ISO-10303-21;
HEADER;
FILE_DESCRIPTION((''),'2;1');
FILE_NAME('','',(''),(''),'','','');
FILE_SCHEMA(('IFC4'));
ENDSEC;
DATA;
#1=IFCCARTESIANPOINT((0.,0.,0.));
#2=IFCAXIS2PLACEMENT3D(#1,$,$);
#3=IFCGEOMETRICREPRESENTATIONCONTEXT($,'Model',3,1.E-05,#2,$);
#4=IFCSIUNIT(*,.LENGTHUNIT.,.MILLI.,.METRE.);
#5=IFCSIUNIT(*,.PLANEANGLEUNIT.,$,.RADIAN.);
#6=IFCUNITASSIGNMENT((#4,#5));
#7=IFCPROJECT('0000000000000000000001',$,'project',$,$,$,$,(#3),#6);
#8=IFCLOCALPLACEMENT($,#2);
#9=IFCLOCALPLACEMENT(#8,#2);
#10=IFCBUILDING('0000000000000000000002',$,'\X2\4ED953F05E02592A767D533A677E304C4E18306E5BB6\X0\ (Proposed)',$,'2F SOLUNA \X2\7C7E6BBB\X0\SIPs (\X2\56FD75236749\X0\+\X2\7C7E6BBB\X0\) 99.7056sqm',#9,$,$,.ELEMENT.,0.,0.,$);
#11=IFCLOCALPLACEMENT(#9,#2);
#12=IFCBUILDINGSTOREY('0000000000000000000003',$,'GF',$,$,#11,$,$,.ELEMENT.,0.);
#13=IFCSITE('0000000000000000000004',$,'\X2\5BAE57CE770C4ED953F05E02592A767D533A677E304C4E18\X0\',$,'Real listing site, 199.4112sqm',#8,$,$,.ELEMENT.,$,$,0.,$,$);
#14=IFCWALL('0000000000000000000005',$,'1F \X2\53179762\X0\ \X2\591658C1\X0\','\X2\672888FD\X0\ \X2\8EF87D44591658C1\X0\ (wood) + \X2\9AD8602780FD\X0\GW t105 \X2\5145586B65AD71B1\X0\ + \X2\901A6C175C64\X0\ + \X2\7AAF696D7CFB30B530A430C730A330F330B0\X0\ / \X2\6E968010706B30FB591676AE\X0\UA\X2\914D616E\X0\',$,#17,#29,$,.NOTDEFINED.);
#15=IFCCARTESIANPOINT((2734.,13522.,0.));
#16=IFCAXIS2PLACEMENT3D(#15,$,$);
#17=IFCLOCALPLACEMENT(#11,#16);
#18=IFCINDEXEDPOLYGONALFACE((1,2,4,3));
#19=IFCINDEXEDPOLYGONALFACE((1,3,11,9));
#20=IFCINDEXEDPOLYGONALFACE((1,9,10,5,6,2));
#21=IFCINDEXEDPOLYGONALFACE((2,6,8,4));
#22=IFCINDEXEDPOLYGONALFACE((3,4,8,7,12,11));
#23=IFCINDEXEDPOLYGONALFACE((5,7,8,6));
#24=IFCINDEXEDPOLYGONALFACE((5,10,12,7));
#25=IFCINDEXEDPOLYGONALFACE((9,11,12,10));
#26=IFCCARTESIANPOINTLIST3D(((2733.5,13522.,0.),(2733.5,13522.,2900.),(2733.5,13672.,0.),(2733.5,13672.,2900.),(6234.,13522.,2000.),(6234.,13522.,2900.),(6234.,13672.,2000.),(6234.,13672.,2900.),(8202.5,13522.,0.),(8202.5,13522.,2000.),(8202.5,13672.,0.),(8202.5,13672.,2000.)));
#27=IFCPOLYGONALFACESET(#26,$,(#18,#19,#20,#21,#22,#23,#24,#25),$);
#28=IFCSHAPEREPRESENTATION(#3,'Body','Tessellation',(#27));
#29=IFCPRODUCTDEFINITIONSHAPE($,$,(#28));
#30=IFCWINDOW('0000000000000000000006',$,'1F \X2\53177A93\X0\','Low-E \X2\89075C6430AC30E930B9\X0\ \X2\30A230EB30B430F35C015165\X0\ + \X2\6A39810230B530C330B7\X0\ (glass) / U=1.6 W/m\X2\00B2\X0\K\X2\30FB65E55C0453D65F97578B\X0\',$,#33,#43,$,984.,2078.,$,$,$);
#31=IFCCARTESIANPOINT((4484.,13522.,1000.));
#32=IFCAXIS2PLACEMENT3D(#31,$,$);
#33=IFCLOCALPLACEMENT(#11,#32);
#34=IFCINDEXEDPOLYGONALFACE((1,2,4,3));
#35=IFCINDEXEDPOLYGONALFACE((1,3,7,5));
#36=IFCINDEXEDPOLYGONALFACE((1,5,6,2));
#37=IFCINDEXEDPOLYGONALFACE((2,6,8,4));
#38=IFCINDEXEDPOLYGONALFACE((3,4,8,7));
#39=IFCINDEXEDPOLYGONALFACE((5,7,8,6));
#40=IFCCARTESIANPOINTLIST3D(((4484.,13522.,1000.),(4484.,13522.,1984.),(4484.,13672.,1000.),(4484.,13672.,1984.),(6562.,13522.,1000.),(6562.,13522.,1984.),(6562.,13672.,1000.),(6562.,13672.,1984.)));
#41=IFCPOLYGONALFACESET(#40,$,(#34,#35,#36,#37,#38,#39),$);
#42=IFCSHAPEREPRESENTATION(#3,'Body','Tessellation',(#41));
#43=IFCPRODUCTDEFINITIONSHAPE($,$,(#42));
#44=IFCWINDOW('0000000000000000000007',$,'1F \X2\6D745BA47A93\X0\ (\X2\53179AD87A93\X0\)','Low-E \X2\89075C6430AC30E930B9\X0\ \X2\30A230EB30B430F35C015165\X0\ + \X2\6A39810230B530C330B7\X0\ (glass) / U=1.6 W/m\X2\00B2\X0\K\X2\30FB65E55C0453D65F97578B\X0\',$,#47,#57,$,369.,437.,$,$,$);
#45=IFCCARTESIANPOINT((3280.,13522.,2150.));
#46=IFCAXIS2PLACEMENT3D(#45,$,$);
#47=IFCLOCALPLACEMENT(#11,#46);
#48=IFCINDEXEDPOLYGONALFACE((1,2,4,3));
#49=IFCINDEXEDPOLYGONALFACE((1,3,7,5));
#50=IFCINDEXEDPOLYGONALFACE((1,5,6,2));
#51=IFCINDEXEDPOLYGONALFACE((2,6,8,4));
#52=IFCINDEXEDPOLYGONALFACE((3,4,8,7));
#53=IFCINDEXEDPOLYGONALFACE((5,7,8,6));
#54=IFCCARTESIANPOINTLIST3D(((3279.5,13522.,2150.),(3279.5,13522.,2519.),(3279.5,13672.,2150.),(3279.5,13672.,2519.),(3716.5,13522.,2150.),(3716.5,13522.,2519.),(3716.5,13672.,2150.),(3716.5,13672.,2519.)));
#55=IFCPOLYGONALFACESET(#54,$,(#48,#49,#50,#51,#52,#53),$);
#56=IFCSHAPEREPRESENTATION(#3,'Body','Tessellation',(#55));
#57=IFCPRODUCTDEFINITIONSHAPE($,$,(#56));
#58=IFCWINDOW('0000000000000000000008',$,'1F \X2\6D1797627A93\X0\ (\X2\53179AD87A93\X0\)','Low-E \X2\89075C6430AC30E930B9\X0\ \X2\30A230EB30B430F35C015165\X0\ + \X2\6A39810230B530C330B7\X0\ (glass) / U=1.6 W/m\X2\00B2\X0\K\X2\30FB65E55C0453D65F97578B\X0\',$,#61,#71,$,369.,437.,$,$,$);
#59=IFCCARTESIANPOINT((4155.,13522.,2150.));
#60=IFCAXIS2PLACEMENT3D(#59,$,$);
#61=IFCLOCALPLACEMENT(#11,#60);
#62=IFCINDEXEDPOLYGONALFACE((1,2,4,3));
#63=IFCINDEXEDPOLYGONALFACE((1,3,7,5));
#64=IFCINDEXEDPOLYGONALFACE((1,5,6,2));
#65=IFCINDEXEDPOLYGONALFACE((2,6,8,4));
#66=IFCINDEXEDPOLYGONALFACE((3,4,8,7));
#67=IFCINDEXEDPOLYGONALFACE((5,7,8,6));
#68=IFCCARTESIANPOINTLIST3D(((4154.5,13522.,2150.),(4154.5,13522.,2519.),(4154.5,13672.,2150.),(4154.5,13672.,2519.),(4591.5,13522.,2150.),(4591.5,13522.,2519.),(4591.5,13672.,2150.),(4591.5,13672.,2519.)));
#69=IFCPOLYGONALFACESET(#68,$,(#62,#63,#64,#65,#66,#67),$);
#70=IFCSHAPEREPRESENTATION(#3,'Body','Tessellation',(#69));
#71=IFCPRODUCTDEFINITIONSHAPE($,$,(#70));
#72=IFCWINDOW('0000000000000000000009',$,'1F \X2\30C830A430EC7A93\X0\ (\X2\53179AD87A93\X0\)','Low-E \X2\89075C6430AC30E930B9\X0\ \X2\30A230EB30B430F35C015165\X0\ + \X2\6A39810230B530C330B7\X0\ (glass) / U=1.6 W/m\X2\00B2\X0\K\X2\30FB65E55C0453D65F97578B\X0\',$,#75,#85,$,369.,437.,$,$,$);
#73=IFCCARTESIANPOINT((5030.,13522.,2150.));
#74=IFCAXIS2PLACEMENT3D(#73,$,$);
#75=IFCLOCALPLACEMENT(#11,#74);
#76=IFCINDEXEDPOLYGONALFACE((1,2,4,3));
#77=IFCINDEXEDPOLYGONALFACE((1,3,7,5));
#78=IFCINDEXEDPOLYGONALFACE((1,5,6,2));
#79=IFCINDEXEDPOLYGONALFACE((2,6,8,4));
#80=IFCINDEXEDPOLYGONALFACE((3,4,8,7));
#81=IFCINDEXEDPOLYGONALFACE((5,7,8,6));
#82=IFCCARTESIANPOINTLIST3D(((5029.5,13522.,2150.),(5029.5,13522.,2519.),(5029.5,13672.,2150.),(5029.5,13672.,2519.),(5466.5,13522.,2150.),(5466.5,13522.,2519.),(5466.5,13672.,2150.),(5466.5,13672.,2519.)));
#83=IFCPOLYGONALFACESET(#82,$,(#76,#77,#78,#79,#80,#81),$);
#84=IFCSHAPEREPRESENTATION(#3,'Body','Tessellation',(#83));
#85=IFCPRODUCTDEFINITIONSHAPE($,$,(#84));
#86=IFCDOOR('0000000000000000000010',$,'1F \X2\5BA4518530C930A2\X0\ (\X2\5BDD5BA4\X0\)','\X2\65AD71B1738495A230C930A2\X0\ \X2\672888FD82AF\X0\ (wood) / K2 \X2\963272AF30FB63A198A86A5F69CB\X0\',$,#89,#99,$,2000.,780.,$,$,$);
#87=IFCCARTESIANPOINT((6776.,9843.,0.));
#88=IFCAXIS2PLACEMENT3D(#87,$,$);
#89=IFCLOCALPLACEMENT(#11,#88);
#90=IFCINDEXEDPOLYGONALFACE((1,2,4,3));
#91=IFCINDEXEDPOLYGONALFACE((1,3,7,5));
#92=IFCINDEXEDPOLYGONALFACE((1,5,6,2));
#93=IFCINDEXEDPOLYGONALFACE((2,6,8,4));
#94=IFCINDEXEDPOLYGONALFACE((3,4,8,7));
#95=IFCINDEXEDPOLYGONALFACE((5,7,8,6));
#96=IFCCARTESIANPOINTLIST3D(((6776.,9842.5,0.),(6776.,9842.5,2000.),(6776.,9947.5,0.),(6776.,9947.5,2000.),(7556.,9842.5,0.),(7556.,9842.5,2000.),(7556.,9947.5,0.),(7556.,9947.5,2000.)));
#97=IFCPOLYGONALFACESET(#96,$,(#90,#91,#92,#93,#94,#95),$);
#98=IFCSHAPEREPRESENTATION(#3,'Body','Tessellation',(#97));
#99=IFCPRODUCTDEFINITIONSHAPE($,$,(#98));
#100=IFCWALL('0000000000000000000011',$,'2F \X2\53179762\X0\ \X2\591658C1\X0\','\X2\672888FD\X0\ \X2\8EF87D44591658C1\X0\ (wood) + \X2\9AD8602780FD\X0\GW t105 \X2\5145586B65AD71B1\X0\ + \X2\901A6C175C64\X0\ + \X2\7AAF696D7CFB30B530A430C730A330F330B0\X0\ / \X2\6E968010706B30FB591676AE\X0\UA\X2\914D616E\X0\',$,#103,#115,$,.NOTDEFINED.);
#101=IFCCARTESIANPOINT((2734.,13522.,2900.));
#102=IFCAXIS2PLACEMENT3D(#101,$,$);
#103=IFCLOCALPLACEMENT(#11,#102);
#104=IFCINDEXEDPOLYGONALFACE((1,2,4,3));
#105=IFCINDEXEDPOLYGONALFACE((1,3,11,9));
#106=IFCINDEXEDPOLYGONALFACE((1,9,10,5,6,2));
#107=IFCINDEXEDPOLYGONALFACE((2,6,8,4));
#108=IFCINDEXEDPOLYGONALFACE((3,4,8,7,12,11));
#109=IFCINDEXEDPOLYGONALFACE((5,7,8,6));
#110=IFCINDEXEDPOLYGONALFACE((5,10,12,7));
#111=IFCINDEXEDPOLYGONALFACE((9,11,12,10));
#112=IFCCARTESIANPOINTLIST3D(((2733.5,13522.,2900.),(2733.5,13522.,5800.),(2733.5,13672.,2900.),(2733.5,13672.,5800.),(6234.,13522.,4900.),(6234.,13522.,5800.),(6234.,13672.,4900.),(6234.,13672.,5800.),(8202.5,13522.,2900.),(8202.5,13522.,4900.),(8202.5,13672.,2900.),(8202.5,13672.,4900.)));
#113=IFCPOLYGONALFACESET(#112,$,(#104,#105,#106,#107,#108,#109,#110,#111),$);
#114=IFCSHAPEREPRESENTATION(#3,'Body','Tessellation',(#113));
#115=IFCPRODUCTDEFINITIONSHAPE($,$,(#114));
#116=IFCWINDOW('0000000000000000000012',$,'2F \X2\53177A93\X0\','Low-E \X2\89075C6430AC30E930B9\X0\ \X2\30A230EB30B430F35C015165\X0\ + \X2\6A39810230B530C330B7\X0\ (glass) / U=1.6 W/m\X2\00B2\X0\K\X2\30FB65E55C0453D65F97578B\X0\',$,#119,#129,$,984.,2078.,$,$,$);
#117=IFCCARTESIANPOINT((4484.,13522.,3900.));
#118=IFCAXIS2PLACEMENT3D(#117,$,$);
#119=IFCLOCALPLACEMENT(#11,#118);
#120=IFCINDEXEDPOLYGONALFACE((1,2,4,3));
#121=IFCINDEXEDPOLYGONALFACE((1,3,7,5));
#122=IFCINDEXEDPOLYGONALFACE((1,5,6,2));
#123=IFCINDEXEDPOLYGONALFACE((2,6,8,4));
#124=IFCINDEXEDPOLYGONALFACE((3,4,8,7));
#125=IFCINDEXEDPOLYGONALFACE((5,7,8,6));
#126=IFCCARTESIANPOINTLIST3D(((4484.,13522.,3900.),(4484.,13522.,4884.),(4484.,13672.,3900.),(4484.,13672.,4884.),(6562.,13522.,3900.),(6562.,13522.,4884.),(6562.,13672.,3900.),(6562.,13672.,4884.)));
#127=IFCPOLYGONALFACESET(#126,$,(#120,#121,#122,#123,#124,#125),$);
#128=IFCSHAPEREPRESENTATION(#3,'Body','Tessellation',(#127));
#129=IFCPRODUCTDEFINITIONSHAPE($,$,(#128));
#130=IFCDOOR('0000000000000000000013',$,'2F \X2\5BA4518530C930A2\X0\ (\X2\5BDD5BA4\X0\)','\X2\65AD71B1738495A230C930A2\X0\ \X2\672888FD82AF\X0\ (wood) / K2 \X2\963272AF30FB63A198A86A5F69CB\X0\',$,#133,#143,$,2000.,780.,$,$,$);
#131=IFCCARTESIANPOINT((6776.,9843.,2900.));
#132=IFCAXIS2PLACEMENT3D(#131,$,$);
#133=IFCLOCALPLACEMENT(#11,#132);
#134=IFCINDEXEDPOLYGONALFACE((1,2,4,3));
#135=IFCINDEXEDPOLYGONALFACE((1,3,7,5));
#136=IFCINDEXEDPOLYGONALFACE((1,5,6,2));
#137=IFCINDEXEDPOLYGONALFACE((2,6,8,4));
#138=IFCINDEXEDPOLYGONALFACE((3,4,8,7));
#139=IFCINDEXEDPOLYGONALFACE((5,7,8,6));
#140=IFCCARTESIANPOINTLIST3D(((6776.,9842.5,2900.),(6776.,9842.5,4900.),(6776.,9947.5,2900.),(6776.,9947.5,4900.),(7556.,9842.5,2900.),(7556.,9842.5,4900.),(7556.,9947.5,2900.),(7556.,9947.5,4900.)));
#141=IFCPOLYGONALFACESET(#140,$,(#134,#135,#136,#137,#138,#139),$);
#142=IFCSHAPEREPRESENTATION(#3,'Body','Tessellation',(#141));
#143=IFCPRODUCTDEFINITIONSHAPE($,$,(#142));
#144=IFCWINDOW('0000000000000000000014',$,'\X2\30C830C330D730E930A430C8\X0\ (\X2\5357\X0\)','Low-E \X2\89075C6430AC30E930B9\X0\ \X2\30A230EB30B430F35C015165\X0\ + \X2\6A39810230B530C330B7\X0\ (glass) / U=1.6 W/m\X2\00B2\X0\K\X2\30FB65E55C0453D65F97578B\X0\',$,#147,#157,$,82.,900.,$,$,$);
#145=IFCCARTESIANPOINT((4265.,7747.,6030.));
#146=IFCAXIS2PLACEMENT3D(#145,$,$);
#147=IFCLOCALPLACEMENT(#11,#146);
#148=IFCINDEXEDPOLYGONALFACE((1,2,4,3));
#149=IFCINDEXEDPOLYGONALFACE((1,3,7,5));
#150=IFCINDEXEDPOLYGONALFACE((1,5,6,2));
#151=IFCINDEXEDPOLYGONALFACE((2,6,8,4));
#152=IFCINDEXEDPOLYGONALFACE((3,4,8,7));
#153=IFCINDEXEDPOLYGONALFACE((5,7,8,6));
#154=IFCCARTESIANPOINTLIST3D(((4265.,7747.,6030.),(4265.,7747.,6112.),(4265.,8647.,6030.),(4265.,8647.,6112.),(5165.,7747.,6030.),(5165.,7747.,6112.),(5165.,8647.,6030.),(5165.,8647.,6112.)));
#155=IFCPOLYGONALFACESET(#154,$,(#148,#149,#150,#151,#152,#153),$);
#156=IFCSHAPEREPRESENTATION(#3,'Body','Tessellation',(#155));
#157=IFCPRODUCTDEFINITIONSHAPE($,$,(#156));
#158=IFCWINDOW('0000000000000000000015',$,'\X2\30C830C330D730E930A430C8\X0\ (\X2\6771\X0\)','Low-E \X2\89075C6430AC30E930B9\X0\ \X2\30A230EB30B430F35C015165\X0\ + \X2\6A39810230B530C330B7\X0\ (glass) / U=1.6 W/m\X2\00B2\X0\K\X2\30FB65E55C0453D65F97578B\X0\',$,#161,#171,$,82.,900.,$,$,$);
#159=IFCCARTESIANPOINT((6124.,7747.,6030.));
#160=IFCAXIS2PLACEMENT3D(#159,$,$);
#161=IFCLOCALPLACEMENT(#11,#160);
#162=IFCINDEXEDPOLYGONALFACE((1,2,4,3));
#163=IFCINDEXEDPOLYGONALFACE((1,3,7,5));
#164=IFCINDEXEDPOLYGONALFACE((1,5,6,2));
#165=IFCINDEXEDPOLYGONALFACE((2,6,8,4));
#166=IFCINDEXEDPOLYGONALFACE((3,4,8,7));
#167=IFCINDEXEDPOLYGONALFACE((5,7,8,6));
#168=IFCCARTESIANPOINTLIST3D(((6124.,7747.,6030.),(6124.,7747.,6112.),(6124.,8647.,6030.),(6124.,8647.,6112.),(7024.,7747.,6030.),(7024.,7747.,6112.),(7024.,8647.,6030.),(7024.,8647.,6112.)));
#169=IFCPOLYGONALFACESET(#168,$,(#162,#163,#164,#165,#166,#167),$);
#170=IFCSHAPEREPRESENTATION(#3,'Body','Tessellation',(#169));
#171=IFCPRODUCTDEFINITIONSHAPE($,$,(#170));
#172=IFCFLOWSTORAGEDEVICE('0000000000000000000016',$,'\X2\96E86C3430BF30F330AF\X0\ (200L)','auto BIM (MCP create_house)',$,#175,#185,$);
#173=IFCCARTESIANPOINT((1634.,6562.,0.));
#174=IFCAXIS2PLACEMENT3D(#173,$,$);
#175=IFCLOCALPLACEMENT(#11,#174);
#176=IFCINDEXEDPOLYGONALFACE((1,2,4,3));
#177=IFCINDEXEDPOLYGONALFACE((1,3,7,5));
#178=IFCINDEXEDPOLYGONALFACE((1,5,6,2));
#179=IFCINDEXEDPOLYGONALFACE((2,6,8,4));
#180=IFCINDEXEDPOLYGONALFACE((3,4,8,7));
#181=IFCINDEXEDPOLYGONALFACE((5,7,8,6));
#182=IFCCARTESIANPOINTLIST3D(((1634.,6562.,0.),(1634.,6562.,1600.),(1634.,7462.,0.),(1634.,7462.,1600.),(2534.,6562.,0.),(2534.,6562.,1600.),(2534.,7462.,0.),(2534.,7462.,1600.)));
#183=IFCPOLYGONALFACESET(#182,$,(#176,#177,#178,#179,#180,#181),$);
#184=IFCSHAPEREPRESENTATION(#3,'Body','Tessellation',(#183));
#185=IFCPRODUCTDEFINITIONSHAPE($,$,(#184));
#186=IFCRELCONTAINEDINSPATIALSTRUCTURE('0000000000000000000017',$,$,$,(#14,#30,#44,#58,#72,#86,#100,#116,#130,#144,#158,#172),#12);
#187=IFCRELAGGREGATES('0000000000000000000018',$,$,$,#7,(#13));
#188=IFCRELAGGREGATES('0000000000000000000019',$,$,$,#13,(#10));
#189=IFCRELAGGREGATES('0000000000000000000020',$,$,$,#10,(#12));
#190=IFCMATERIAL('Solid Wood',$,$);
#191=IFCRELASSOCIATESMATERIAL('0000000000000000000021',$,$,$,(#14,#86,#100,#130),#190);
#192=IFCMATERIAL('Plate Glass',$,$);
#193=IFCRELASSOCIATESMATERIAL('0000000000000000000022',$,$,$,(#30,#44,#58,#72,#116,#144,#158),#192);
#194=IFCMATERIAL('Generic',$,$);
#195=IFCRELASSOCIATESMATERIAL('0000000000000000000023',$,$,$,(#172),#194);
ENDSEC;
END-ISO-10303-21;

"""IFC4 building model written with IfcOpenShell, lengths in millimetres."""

from ifc_helpers import new_model, si_unit, frame, frame_2d, origin, place, context, project, spatial, rectangle, extrude, material, element, fill, save


model = new_model("IFC4")

# Units and contexts
model_context = context("Model", 3, precision=1e-05, world=origin())
ifc_project = project(units=[si_unit("LENGTHUNIT", "METRE", prefix="MILLI"), si_unit("PLANEANGLEUNIT", "RADIAN")], contexts=[model_context])

# Site, building, storey
site_placement = place(None, origin())
site = spatial("IfcSite", under=ifc_project, at=site_placement, Name="宮城県仙台市太白区松が丘", ObjectType="Real listing site, 199.4112sqm", CompositionType="ELEMENT", RefElevation=0.0)
building_placement = place(site_placement, origin())
building = spatial("IfcBuilding", under=site, at=building_placement, Name="仙台市太白区松が丘の家 (Proposed)", ObjectType="2F SOLUNA 籾殻SIPs (国産杉+籾殻) 99.7056sqm", CompositionType="ELEMENT", ElevationOfRefHeight=0.0, ElevationOfTerrain=0.0)
storey_placement = place(building_placement, origin())
storey = spatial("IfcBuildingStorey", under=building, at=storey_placement, Name="GF", CompositionType="ELEMENT", Elevation=0.0)

# Wall, openings, windows
ifc_material_1 = material(Name="Solid Wood")
wall_1_placement = place(storey_placement, frame((2734.0, 13522.0, 0.0)))
wall_1 = element("IfcWall", 1, at=wall_1_placement, inside=storey, material=ifc_material_1, Name="1F 北面 外壁", Description="木製 軸組外壁 (wood) + 高性能GW t105 充填断熱 + 通気層 + 窯業系サイディング / 準耐火・外皮UA配慮", PredefinedType="NOTDEFINED", context=model_context, shape_type="SweptSolid", body=[
    extrude(rectangle(XDim=5469.0, YDim=150.0, at=frame_2d((2734.0, 75.0))), frame((2734.0, 13522.0, 0.0)), (0.0, 0.0, 1.0), 2900.0),
])
opening_1_placement = place(storey_placement, frame((4484.0, 13522.0, 1000.0)))
opening_1 = element("IfcOpeningElement", 2, at=opening_1_placement, cuts=wall_1, PredefinedType="NOTDEFINED", context=model_context, shape_type="SweptSolid", body=[
    extrude(rectangle(XDim=2078.0, YDim=150.0, at=frame_2d((1039.0, 75.0))), frame((4484.0, 13522.0, 1000.0)), (0.0, 0.0, 1.0), 984.0),
])
opening_2_placement = place(storey_placement, frame((3280.0, 13522.0, 2150.0)))
opening_2 = element("IfcOpeningElement", 3, at=opening_2_placement, cuts=wall_1, PredefinedType="NOTDEFINED", context=model_context, shape_type="SweptSolid", body=[
    extrude(rectangle(XDim=437.0, YDim=150.0, at=frame_2d((218.0, 75.0))), frame((3280.0, 13522.0, 2150.0)), (0.0, 0.0, 1.0), 369.0),
])
opening_3_placement = place(storey_placement, frame((4155.0, 13522.0, 2150.0)))
opening_3 = element("IfcOpeningElement", 4, at=opening_3_placement, cuts=wall_1, PredefinedType="NOTDEFINED", context=model_context, shape_type="SweptSolid", body=[
    extrude(rectangle(XDim=437.0, YDim=150.0, at=frame_2d((218.0, 75.0))), frame((4155.0, 13522.0, 2150.0)), (0.0, 0.0, 1.0), 369.0),
])
opening_4_placement = place(storey_placement, frame((5030.0, 13522.0, 2150.0)))
opening_4 = element("IfcOpeningElement", 5, at=opening_4_placement, cuts=wall_1, PredefinedType="NOTDEFINED", context=model_context, shape_type="SweptSolid", body=[
    extrude(rectangle(XDim=437.0, YDim=150.0, at=frame_2d((218.0, 75.0))), frame((5030.0, 13522.0, 2150.0)), (0.0, 0.0, 1.0), 369.0),
])
ifc_material_2 = material(Name="Plate Glass")
window_1_placement = place(storey_placement, frame((4484.0, 13522.0, 1000.0)))
window_1 = element("IfcWindow", 6, at=window_1_placement, inside=storey, material=ifc_material_2, Name="1F 北窓", Description="Low-E 複層ガラス アルゴン封入 + 樹脂サッシ (glass) / U=1.6 W/m²K・日射取得型", OverallHeight=984.0, OverallWidth=2078.0, context=model_context, shape_type="SweptSolid", body=[
    extrude(rectangle(XDim=2078.0, YDim=150.0, at=frame_2d((1039.0, 75.0))), frame((4484.0, 13522.0, 1000.0)), (0.0, 0.0, 1.0), 984.0),
])
fill(opening_1, window_1)
window_2_placement = place(storey_placement, frame((3280.0, 13522.0, 2150.0)))
window_2 = element("IfcWindow", 7, at=window_2_placement, inside=storey, material=ifc_material_2, Name="1F 浴室窓 (北高窓)", Description="Low-E 複層ガラス アルゴン封入 + 樹脂サッシ (glass) / U=1.6 W/m²K・日射取得型", OverallHeight=369.0, OverallWidth=437.0, context=model_context, shape_type="SweptSolid", body=[
    extrude(rectangle(XDim=437.0, YDim=150.0, at=frame_2d((218.0, 75.0))), frame((3280.0, 13522.0, 2150.0)), (0.0, 0.0, 1.0), 369.0),
])
fill(opening_2, window_2)
window_3_placement = place(storey_placement, frame((4155.0, 13522.0, 2150.0)))
window_3 = element("IfcWindow", 8, at=window_3_placement, inside=storey, material=ifc_material_2, Name="1F 洗面窓 (北高窓)", Description="Low-E 複層ガラス アルゴン封入 + 樹脂サッシ (glass) / U=1.6 W/m²K・日射取得型", OverallHeight=369.0, OverallWidth=437.0, context=model_context, shape_type="SweptSolid", body=[
    extrude(rectangle(XDim=437.0, YDim=150.0, at=frame_2d((218.0, 75.0))), frame((4155.0, 13522.0, 2150.0)), (0.0, 0.0, 1.0), 369.0),
])
fill(opening_3, window_3)
window_4_placement = place(storey_placement, frame((5030.0, 13522.0, 2150.0)))
window_4 = element("IfcWindow", 9, at=window_4_placement, inside=storey, material=ifc_material_2, Name="1F トイレ窓 (北高窓)", Description="Low-E 複層ガラス アルゴン封入 + 樹脂サッシ (glass) / U=1.6 W/m²K・日射取得型", OverallHeight=369.0, OverallWidth=437.0, context=model_context, shape_type="SweptSolid", body=[
    extrude(rectangle(XDim=437.0, YDim=150.0, at=frame_2d((218.0, 75.0))), frame((5030.0, 13522.0, 2150.0)), (0.0, 0.0, 1.0), 369.0),
])
fill(opening_4, window_4)

# Door
door_1_placement = place(storey_placement, frame((6776.0, 9843.0, 0.0)))
element("IfcDoor", 10, at=door_1_placement, inside=storey, material=ifc_material_1, Name="1F 室内ドア (寝室)", Description="断熱玄関ドア 木製芯 (wood) / K2 防犯・採風機構", OverallHeight=2000.0, OverallWidth=780.0, context=model_context, shape_type="SweptSolid", body=[
    extrude(rectangle(XDim=780.0, YDim=105.0, at=frame_2d((390.0, 52.0))), frame((6776.0, 9843.0, 0.0)), (0.0, 0.0, 1.0), 2000.0),
])

# Wall, opening, window
wall_2_placement = place(storey_placement, frame((2734.0, 13522.0, 2900.0)))
wall_2 = element("IfcWall", 11, at=wall_2_placement, inside=storey, material=ifc_material_1, Name="2F 北面 外壁", Description="木製 軸組外壁 (wood) + 高性能GW t105 充填断熱 + 通気層 + 窯業系サイディング / 準耐火・外皮UA配慮", PredefinedType="NOTDEFINED", context=model_context, shape_type="SweptSolid", body=[
    extrude(rectangle(XDim=5469.0, YDim=150.0, at=frame_2d((2734.0, 75.0))), frame((2734.0, 13522.0, 2900.0)), (0.0, 0.0, 1.0), 2900.0),
])
opening_5_placement = place(storey_placement, frame((4484.0, 13522.0, 3900.0)))
opening_5 = element("IfcOpeningElement", 12, at=opening_5_placement, cuts=wall_2, PredefinedType="NOTDEFINED", context=model_context, shape_type="SweptSolid", body=[
    extrude(rectangle(XDim=2078.0, YDim=150.0, at=frame_2d((1039.0, 75.0))), frame((4484.0, 13522.0, 3900.0)), (0.0, 0.0, 1.0), 984.0),
])
window_5_placement = place(storey_placement, frame((4484.0, 13522.0, 3900.0)))
window_5 = element("IfcWindow", 13, at=window_5_placement, inside=storey, material=ifc_material_2, Name="2F 北窓", Description="Low-E 複層ガラス アルゴン封入 + 樹脂サッシ (glass) / U=1.6 W/m²K・日射取得型", OverallHeight=984.0, OverallWidth=2078.0, context=model_context, shape_type="SweptSolid", body=[
    extrude(rectangle(XDim=2078.0, YDim=150.0, at=frame_2d((1039.0, 75.0))), frame((4484.0, 13522.0, 3900.0)), (0.0, 0.0, 1.0), 984.0),
])
fill(opening_5, window_5)

# Door
door_2_placement = place(storey_placement, frame((6776.0, 9843.0, 2900.0)))
element("IfcDoor", 14, at=door_2_placement, inside=storey, material=ifc_material_1, Name="2F 室内ドア (寝室)", Description="断熱玄関ドア 木製芯 (wood) / K2 防犯・採風機構", OverallHeight=2000.0, OverallWidth=780.0, context=model_context, shape_type="SweptSolid", body=[
    extrude(rectangle(XDim=780.0, YDim=105.0, at=frame_2d((390.0, 52.0))), frame((6776.0, 9843.0, 2900.0)), (0.0, 0.0, 1.0), 2000.0),
])

# Windows
window_6_placement = place(storey_placement, frame((4265.0, 7747.0, 6030.0)))
element("IfcWindow", 15, at=window_6_placement, inside=storey, material=ifc_material_2, Name="トップライト (南)", Description="Low-E 複層ガラス アルゴン封入 + 樹脂サッシ (glass) / U=1.6 W/m²K・日射取得型", OverallHeight=82.0, OverallWidth=900.0, context=model_context, shape_type="SweptSolid", body=[
    extrude(rectangle(XDim=900.0, YDim=900.0, at=frame_2d((450.0, 450.0))), frame((4265.0, 7747.0, 6030.0)), (0.0, 0.0, 1.0), 82.0),
])
window_7_placement = place(storey_placement, frame((6124.0, 7747.0, 6030.0)))
element("IfcWindow", 16, at=window_7_placement, inside=storey, material=ifc_material_2, Name="トップライト (東)", Description="Low-E 複層ガラス アルゴン封入 + 樹脂サッシ (glass) / U=1.6 W/m²K・日射取得型", OverallHeight=82.0, OverallWidth=900.0, context=model_context, shape_type="SweptSolid", body=[
    extrude(rectangle(XDim=900.0, YDim=900.0, at=frame_2d((450.0, 450.0))), frame((6124.0, 7747.0, 6030.0)), (0.0, 0.0, 1.0), 82.0),
])

# Flow storage device
ifc_material_3 = material(Name="Generic")
flow_storage_device_placement = place(storey_placement, frame((1634.0, 6562.0, 0.0)))
element("IfcFlowStorageDevice", 17, at=flow_storage_device_placement, inside=storey, material=ifc_material_3, Name="雨水タンク (200L)", Description="auto BIM (MCP create_house)", context=model_context, shape_type="SweptSolid", body=[
    extrude(rectangle(XDim=900.0, YDim=900.0, at=frame_2d((450.0, 450.0))), frame((1634.0, 6562.0, 0.0)), (0.0, 0.0, 1.0), 1600.0),
])

save(model, "model.ifc")
